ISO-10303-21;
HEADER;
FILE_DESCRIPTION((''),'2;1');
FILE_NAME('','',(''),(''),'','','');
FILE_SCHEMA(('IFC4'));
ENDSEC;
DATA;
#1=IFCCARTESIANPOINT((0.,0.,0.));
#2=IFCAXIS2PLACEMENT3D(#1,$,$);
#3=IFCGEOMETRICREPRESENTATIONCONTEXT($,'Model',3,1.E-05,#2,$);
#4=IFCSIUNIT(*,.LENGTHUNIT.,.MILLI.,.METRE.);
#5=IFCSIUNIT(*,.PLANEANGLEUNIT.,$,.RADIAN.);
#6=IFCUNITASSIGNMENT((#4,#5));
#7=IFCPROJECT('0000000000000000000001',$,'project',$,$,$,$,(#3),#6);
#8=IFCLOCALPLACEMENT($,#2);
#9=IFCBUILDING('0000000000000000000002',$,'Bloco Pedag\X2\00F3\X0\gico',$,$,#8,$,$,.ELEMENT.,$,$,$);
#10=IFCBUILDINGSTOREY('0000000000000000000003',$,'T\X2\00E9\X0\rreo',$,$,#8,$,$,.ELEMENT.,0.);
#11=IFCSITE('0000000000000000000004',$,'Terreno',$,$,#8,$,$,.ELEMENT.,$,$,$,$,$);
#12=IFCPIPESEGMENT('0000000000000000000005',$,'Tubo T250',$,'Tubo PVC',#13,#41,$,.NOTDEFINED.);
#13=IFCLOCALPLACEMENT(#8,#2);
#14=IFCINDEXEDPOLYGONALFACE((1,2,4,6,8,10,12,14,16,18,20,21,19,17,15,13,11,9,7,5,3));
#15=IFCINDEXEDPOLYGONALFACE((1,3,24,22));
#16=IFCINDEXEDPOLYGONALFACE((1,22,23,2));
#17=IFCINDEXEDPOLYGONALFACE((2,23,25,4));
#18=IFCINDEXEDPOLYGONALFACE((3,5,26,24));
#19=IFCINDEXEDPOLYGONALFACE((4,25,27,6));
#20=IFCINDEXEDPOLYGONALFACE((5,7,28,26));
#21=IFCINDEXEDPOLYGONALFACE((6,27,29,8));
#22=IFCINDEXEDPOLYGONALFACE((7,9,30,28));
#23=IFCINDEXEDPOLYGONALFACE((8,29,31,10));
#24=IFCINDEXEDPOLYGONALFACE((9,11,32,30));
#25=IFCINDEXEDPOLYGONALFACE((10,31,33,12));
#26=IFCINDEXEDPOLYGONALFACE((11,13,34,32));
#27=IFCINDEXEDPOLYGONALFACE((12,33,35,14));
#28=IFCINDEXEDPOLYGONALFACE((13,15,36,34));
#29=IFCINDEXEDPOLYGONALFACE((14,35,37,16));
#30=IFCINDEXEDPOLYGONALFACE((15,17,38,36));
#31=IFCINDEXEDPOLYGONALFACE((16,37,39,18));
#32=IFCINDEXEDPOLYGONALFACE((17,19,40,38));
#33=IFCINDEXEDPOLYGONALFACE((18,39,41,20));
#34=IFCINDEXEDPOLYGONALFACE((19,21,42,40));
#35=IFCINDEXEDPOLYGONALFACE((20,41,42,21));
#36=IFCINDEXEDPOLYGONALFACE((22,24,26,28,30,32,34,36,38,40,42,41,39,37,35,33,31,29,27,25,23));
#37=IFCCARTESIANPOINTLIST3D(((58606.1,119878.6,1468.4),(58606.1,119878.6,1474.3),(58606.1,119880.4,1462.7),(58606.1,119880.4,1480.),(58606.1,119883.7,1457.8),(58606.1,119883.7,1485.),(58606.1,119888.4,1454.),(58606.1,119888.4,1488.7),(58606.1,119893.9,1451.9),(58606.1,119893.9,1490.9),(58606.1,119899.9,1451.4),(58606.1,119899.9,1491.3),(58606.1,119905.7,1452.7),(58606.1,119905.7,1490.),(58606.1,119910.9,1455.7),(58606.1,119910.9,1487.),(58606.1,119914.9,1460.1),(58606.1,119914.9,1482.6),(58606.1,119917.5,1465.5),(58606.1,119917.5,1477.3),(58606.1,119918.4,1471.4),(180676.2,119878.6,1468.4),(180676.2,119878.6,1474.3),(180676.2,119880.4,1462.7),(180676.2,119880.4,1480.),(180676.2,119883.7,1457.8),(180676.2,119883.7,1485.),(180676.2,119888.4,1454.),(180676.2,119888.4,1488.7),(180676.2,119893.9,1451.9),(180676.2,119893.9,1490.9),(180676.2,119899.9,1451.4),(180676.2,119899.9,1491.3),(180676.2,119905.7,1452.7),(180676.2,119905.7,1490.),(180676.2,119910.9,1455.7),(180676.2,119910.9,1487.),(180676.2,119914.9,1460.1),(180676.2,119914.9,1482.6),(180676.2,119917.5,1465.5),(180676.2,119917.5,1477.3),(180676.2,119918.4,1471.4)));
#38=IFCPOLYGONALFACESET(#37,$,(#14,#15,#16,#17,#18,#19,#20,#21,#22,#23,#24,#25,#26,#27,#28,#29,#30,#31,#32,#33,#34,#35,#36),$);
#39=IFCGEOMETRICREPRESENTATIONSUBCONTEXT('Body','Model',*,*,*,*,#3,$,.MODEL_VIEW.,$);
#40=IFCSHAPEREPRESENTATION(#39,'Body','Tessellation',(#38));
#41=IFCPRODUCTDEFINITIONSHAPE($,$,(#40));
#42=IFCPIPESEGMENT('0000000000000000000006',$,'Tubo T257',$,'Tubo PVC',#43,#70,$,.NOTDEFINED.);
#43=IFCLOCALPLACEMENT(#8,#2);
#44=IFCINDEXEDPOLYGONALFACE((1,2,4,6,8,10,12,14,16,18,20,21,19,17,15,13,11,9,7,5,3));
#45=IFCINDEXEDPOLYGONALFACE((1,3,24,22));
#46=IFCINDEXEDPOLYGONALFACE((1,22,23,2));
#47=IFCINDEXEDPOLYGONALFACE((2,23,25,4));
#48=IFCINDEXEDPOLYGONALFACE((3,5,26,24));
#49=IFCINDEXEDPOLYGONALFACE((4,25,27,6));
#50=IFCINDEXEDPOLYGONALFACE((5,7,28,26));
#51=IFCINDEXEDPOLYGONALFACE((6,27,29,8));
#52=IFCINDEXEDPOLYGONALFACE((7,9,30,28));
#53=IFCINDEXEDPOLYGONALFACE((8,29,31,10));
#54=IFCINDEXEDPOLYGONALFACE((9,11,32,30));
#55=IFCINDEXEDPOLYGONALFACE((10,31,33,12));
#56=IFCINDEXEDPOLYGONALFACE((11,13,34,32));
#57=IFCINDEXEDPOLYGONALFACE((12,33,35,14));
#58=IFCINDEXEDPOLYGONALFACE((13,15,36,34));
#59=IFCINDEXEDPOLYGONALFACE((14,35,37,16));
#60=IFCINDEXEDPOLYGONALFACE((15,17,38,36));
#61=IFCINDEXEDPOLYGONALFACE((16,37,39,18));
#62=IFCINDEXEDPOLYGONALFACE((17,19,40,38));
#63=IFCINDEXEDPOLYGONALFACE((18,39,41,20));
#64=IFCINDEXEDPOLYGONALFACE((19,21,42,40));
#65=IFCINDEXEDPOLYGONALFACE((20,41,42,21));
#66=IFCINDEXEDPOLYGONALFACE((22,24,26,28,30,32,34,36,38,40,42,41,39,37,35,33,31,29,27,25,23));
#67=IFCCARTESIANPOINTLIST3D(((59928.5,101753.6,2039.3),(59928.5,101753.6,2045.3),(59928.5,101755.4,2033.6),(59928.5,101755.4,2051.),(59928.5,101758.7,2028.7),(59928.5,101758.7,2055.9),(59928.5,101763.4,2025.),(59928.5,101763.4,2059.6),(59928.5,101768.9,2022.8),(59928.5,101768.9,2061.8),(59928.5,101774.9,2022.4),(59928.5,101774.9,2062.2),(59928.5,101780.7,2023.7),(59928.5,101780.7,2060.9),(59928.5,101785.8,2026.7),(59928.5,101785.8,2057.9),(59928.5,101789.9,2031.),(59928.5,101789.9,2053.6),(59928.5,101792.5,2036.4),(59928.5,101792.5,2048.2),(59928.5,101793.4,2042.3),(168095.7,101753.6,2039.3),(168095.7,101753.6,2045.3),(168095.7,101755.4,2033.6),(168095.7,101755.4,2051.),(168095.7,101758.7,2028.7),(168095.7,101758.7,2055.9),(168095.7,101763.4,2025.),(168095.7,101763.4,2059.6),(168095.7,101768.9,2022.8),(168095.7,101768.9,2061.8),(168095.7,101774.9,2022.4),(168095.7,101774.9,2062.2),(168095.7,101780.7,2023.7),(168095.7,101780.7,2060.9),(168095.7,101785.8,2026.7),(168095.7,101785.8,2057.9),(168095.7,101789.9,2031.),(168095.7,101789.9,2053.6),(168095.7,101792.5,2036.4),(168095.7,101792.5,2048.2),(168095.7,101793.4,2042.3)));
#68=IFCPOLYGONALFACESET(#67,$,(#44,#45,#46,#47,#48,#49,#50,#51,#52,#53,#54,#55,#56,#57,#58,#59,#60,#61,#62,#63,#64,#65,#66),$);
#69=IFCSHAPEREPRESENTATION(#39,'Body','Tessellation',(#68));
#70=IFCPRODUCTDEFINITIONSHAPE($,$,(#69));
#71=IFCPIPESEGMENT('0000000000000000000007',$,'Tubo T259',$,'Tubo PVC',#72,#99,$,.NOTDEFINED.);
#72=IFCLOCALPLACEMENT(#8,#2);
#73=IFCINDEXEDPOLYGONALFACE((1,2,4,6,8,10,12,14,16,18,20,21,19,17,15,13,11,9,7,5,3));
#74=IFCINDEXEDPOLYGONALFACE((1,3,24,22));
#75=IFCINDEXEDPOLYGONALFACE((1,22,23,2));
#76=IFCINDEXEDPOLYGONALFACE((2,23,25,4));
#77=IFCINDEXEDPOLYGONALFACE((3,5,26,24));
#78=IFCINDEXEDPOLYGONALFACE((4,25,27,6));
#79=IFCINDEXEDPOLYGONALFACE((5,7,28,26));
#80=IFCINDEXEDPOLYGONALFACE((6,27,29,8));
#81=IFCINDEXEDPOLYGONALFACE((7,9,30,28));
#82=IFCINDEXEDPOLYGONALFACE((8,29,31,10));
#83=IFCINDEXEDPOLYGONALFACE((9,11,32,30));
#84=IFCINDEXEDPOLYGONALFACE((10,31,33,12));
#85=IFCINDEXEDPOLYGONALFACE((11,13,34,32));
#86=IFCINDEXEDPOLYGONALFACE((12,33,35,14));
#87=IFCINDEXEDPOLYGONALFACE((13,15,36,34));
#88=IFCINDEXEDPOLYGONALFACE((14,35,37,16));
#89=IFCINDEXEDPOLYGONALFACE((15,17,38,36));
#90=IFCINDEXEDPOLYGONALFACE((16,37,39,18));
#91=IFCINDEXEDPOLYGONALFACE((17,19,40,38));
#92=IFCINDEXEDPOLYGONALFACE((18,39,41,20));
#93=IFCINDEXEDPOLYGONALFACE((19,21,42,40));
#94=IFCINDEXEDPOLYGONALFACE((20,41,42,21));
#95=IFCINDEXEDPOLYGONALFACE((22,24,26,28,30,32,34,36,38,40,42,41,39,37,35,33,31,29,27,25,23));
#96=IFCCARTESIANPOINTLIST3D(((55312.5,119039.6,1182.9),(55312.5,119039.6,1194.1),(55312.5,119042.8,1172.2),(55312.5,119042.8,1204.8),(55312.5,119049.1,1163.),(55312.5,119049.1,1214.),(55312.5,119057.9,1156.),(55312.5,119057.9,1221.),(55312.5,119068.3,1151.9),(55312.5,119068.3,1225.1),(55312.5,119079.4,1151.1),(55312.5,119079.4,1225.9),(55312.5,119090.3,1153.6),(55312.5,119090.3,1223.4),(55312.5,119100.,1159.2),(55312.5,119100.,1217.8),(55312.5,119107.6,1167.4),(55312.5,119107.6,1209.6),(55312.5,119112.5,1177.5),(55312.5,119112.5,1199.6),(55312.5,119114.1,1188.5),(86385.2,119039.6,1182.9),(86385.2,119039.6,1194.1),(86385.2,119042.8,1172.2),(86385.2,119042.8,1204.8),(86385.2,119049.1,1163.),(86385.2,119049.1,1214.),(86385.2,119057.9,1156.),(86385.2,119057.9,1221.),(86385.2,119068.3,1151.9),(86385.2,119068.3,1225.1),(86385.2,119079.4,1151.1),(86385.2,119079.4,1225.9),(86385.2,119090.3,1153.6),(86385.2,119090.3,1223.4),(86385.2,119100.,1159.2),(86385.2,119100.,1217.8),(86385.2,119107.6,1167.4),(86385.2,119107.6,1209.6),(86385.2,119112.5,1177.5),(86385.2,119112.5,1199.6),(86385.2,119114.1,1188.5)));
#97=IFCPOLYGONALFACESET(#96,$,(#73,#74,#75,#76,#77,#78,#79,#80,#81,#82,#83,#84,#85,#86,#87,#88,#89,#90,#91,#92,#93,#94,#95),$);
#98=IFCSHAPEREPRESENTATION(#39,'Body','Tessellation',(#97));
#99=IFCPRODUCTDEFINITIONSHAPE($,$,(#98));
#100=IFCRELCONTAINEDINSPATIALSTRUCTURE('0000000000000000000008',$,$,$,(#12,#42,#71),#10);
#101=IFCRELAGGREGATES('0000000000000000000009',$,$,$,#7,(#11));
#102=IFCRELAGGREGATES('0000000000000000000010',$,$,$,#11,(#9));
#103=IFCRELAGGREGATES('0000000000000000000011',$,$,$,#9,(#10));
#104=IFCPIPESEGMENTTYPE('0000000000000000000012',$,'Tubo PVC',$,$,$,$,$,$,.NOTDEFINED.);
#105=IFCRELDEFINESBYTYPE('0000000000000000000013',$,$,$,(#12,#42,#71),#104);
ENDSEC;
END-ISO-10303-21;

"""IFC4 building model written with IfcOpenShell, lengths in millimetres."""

from ifc_helpers import new_model, si_unit, frame, origin, origin_2d, place, context, subcontext, project, spatial, circle, extrude, type_object, element, save


model = new_model("IFC4")

# Units and contexts
model_context = context("Model", 3, precision=1e-05, world=origin())
body_context = subcontext(model_context, "Body", "Model", "MODEL_VIEW")
ifc_project = project(units=[si_unit("LENGTHUNIT", "METRE", prefix="MILLI"), si_unit("PLANEANGLEUNIT", "RADIAN")], contexts=[model_context])

# Site, building, storey
placement = place(None, origin())
site = spatial("IfcSite", under=ifc_project, at=placement, Name="Terreno", CompositionType="ELEMENT")
building = spatial("IfcBuilding", under=site, at=placement, Name="Bloco Pedagógico", CompositionType="ELEMENT")
storey = spatial("IfcBuildingStorey", under=building, at=placement, Name="Térreo", CompositionType="ELEMENT", Elevation=0.0)

# Pipe segments
pipe_segment_type = type_object("IfcPipeSegmentType", Name="Tubo PVC", PredefinedType="NOTDEFINED")
pipe_segment_1_placement = place(None, frame((58606.1, 119898.4, 1471.4), z_axis=(1.0, 0.0, 0.0), x_axis=(0.0, 1.0, 0.0)))
element("IfcPipeSegment", 1, at=pipe_segment_1_placement, inside=storey, type_object=pipe_segment_type, Name="Tubo T250", ObjectType="Tubo PVC", PredefinedType="NOTDEFINED", context=body_context, shape_type="SweptSolid", body=[
    extrude(circle(Radius=20.0, at=origin_2d()), None, (0.0, 0.0, 1.0), 122070.2),
])
pipe_segment_2_placement = place(None, frame((59928.5, 101773.4, 2042.3), z_axis=(1.0, 0.0, 0.0), x_axis=(0.0, 1.0, 0.0)))
element("IfcPipeSegment", 2, at=pipe_segment_2_placement, inside=storey, type_object=pipe_segment_type, Name="Tubo T257", ObjectType="Tubo PVC", PredefinedType="NOTDEFINED", context=body_context, shape_type="SweptSolid", body=[
    extrude(circle(Radius=20.0, at=origin_2d()), None, (0.0, 0.0, 1.0), 108167.2),
])
pipe_segment_3_placement = place(None, frame((55312.5, 119076.6, 1188.5), z_axis=(1.0, 0.0, 0.0), x_axis=(0.0, 1.0, 0.0)))
element("IfcPipeSegment", 3, at=pipe_segment_3_placement, inside=storey, type_object=pipe_segment_type, Name="Tubo T259", ObjectType="Tubo PVC", PredefinedType="NOTDEFINED", context=body_context, shape_type="SweptSolid", body=[
    extrude(circle(Radius=37.5, at=origin_2d()), None, (0.0, 0.0, 1.0), 31072.7),
])

save(model, "model.ifc")
